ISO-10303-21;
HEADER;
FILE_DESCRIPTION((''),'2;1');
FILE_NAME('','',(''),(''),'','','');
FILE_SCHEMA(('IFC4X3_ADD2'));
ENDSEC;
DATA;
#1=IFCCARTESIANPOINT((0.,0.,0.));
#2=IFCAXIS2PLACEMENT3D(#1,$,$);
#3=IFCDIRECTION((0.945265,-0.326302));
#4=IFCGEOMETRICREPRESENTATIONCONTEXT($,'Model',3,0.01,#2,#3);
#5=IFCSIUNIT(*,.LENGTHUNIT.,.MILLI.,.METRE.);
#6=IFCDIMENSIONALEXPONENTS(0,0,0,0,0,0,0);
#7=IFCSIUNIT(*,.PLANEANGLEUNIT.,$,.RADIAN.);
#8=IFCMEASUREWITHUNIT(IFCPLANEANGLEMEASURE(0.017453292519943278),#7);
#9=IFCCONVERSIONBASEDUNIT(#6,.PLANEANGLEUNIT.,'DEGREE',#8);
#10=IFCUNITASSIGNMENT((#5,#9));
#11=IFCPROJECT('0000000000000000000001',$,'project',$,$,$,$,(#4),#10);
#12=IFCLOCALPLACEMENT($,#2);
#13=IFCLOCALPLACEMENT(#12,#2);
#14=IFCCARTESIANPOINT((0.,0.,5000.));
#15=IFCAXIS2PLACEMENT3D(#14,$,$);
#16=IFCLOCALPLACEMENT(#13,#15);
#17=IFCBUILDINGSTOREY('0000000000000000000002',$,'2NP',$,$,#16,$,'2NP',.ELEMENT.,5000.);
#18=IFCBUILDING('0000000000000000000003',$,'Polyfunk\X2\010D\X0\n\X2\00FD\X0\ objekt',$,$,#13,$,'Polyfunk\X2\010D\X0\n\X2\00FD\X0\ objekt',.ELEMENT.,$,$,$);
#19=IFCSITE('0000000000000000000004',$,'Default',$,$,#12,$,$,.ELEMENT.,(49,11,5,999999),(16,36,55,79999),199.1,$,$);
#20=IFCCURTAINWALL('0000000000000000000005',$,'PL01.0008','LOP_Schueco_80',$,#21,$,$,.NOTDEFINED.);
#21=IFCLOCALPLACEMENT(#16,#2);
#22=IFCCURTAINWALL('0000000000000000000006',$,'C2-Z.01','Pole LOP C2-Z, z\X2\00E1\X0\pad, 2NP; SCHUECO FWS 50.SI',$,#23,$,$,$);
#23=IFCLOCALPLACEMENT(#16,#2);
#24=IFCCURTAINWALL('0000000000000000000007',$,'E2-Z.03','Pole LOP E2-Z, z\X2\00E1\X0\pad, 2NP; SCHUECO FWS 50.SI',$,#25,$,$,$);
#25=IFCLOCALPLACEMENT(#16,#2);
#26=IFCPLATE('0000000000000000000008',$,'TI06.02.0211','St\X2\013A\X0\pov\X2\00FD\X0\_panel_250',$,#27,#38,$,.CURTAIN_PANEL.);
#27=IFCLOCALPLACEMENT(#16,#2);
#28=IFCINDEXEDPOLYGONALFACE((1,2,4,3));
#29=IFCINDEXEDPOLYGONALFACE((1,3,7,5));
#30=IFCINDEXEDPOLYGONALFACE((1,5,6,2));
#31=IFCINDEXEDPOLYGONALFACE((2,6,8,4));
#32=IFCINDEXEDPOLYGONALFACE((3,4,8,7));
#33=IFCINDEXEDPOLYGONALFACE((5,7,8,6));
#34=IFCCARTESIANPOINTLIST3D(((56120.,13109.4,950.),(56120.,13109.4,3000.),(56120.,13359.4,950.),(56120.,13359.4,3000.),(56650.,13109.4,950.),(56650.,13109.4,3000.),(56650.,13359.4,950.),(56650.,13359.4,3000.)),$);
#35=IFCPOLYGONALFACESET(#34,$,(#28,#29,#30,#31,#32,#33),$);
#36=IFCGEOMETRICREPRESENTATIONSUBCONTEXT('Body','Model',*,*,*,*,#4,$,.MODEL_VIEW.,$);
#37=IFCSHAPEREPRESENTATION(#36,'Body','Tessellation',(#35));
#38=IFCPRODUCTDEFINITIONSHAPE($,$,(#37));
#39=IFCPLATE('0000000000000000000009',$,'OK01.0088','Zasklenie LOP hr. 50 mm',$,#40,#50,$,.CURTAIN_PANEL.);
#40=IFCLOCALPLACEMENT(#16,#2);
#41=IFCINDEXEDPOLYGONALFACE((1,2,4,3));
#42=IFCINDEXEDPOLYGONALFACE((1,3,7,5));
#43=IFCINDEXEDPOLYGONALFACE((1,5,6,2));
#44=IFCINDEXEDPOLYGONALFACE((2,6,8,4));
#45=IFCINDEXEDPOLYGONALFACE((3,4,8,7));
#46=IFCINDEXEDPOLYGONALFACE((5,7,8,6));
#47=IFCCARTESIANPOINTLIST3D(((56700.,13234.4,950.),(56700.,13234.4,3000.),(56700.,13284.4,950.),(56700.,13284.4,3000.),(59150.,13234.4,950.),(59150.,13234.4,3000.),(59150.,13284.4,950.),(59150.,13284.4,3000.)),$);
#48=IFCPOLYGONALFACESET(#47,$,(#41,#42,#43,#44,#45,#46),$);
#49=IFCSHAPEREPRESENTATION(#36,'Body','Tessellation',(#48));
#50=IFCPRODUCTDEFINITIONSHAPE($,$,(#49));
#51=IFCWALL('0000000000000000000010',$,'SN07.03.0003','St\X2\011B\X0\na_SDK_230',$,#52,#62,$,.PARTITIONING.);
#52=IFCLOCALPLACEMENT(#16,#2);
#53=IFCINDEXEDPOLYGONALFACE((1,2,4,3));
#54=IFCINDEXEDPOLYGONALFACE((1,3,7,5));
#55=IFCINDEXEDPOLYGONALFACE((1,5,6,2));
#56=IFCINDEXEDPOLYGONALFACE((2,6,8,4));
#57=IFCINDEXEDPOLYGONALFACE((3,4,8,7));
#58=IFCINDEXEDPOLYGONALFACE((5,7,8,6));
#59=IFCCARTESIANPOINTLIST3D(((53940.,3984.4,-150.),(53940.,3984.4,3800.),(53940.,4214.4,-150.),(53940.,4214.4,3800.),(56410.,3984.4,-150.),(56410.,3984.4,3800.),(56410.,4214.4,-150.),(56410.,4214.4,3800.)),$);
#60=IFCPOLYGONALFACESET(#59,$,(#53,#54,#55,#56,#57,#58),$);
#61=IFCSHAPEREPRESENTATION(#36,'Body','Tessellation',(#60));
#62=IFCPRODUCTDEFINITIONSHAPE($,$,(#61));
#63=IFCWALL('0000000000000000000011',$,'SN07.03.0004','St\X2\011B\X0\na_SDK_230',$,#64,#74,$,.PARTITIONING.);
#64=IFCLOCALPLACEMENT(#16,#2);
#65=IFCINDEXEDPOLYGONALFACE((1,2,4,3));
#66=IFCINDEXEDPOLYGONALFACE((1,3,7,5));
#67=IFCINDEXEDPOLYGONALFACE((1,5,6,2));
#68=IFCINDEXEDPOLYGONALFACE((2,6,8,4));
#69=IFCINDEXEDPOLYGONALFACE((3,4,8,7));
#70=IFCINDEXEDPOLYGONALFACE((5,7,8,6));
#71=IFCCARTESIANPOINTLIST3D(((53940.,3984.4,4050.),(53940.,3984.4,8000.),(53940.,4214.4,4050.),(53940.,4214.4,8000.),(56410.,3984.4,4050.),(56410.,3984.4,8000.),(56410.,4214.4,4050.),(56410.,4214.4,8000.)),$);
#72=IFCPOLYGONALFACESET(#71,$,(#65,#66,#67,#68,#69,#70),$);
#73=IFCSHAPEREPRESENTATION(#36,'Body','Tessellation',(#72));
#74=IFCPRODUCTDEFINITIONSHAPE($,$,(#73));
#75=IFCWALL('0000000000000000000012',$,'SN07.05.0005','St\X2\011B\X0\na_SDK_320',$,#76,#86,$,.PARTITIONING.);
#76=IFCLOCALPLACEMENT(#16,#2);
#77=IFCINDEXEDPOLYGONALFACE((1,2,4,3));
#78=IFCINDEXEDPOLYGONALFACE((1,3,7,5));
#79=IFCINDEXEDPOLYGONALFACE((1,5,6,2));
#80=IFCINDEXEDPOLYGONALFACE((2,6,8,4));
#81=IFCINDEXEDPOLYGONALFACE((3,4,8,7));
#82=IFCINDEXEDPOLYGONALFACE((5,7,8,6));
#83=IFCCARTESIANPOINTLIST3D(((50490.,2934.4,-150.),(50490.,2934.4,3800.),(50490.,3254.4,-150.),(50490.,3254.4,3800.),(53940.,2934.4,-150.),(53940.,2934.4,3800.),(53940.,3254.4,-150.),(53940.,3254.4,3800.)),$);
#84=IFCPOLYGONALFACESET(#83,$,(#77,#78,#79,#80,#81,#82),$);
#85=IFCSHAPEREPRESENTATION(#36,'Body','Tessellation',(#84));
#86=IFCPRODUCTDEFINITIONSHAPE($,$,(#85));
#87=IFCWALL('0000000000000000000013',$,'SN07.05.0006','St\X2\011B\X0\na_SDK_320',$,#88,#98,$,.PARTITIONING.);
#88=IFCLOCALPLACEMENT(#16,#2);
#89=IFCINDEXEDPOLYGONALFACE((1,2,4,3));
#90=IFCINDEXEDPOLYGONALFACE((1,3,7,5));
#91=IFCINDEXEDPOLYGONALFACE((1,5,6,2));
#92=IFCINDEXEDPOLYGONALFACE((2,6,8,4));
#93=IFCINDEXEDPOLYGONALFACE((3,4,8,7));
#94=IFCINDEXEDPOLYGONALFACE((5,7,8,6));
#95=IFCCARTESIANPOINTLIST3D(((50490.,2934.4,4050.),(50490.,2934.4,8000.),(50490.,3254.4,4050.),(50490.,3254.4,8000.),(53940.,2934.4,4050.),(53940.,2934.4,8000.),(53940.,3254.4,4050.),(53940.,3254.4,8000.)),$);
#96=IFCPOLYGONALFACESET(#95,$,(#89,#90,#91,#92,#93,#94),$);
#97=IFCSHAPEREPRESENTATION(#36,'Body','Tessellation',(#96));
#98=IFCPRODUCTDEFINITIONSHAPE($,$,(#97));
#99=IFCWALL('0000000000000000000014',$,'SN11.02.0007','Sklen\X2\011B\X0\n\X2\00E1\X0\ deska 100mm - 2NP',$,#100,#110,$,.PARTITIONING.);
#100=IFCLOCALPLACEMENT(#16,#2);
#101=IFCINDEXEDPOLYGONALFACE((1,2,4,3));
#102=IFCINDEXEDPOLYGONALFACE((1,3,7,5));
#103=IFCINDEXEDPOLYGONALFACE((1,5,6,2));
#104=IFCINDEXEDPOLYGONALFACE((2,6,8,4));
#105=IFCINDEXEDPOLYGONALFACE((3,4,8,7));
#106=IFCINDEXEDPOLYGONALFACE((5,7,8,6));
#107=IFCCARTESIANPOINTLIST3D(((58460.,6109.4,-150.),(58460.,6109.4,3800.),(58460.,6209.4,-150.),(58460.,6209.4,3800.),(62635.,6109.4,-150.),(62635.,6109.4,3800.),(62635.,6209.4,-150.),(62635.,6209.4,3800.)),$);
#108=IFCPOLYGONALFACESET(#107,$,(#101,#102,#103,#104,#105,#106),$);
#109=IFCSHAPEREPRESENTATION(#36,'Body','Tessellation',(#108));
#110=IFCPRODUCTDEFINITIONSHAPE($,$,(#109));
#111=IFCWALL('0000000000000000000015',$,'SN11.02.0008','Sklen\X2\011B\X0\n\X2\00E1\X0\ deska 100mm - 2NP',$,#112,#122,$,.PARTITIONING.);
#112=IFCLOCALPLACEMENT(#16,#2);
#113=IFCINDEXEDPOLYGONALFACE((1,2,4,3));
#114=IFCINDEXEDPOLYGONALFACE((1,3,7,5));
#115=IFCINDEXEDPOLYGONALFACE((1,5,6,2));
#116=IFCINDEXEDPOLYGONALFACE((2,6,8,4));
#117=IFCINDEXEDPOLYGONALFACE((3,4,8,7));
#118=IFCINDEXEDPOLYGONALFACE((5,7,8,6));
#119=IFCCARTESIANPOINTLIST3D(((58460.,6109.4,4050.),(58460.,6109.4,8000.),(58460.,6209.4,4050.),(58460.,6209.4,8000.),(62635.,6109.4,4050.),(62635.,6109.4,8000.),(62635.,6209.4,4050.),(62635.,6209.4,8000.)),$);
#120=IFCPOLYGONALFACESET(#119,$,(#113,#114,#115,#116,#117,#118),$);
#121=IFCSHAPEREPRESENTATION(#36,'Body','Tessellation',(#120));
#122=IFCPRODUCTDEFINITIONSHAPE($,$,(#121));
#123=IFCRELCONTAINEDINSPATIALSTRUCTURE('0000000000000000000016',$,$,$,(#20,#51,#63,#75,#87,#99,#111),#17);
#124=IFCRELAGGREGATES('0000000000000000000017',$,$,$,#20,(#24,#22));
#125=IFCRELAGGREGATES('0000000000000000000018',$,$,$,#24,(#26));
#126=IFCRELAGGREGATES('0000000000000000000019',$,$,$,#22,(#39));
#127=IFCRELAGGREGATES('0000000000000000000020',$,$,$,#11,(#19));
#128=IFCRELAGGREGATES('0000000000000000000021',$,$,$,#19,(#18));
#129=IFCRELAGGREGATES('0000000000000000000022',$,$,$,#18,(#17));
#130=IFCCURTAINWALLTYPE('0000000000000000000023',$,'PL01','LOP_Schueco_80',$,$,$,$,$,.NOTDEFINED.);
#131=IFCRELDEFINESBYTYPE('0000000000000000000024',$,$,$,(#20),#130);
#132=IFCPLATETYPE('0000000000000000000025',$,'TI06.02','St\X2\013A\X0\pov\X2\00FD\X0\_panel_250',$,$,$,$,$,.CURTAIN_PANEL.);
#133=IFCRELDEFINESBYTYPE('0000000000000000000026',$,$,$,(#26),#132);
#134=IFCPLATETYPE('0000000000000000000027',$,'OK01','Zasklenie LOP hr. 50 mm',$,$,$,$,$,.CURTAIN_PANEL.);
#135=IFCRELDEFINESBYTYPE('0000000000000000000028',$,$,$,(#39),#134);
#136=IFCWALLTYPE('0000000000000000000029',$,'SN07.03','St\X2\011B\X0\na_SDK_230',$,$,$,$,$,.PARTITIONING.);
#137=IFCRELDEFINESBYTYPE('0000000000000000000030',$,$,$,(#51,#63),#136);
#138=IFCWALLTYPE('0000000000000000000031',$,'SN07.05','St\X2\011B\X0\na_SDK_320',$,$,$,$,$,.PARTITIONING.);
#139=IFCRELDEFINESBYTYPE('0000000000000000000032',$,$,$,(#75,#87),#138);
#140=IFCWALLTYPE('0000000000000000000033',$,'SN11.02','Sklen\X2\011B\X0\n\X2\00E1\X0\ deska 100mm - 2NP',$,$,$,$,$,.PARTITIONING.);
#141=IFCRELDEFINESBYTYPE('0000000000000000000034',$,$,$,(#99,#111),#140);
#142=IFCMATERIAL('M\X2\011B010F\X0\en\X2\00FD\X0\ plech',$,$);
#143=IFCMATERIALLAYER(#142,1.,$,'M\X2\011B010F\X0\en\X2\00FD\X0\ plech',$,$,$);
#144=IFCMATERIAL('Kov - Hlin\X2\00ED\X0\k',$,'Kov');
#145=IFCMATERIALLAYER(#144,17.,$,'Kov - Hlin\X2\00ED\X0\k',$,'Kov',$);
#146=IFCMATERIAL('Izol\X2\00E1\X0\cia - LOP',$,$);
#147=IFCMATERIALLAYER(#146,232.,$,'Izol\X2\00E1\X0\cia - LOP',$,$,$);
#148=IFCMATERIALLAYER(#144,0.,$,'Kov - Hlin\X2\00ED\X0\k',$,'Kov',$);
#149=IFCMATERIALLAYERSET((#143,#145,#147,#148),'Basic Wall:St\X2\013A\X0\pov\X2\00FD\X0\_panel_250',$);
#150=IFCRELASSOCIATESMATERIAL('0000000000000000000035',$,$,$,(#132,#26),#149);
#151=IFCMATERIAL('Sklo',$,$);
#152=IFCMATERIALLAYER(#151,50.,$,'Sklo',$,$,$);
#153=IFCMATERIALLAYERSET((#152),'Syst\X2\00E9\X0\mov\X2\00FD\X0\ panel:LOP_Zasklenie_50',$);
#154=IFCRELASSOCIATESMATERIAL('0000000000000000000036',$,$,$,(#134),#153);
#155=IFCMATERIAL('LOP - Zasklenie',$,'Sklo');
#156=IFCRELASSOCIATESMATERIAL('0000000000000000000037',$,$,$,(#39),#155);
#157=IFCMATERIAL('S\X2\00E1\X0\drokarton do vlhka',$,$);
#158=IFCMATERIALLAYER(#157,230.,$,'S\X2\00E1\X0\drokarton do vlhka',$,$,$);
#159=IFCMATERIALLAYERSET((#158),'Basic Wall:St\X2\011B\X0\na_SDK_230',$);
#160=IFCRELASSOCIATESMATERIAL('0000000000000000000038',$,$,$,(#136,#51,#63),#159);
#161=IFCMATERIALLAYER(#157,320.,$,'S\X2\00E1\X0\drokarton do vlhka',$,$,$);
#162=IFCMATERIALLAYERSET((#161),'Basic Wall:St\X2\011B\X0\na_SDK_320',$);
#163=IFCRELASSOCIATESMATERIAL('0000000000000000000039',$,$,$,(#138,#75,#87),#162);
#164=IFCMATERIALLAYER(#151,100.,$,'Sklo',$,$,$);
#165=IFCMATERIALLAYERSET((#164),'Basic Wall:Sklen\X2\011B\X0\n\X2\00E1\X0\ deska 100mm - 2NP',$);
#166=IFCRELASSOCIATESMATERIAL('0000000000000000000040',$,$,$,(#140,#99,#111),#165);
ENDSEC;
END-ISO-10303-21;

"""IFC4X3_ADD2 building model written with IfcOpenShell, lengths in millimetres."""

from ifc_helpers import new_model, entity, si_unit, converted_unit, direction, frame, frame_2d, origin, origin_2d_with_axis, place, context, subcontext, project, spatial, polyline, rectangle, extrude, clip, bounded_halfspace, source, transform, mapped, material, layer, layer_set, layer_usage, type_object, type_shapes, element, aggregate, save


model = new_model("IFC4X3_ADD2")

# Units and contexts
model_context = context("Model", 3, precision=0.01, world=origin(), true_north=direction((0.945265, -0.326302)))
body_context = subcontext(model_context, "Body", "Model", "MODEL_VIEW")
ifc_project = project(units=[si_unit("LENGTHUNIT", "METRE", prefix="MILLI"), converted_unit("PLANEANGLEUNIT", "DEGREE", entity("IfcPlaneAngleMeasure", 0.017453292519943278), si_unit("PLANEANGLEUNIT", "RADIAN"), dimensions=[0, 0, 0, 0, 0, 0, 0])], contexts=[model_context])

# Site, building, storey
site_placement = place(None, origin())
site = spatial("IfcSite", under=ifc_project, at=site_placement, Name="Default", CompositionType="ELEMENT", RefLatitude=(49, 11, 5, 999999), RefLongitude=(16, 36, 55, 79999), RefElevation=199.1)
building_placement = place(site_placement, origin())
building = spatial("IfcBuilding", under=site, at=building_placement, Name="Polyfunkčný objekt", LongName="Polyfunkčný objekt", CompositionType="ELEMENT")
storey_placement = place(building_placement, frame((0.0, 0.0, 5000.0)))
storey = spatial("IfcBuildingStorey", under=building, at=storey_placement, Name="2NP", LongName="2NP", CompositionType="ELEMENT", Elevation=5000.0)

# Curtain walls, plates
curtain_wall_type = type_object("IfcCurtainWallType", Name="PL01", Description="LOP_Schueco_80", PredefinedType="NOTDEFINED")
curtain_wall_1_placement = place(storey_placement, frame((0.0, 0.0, -5000.0)))
curtain_wall_1 = element("IfcCurtainWall", 1, at=curtain_wall_1_placement, inside=storey, type_object=curtain_wall_type, Name="PL01.0008", Description="LOP_Schueco_80", PredefinedType="NOTDEFINED")
curtain_wall_2 = element("IfcCurtainWall", 2, Name="C2-Z.01", Description="Pole LOP C2-Z, západ, 2NP; SCHUECO FWS 50.SI")
curtain_wall_3 = element("IfcCurtainWall", 3, Name="E2-Z.03", Description="Pole LOP E2-Z, západ, 2NP; SCHUECO FWS 50.SI")
aggregate(curtain_wall_1, [curtain_wall_3, curtain_wall_2])
ifc_material_1 = material(Name="Měďený plech")
ifc_layer_1 = layer(ifc_material_1, 1.0, Name="Měďený plech")
ifc_material_2 = material(Name="Kov - Hliník", Category="Kov")
ifc_layer_2 = layer(ifc_material_2, 17.0, Name="Kov - Hliník", Category="Kov")
ifc_material_3 = material(Name="Izolácia - LOP")
ifc_layer_3 = layer(ifc_material_3, 232.0, Name="Izolácia - LOP")
ifc_layer_4 = layer(ifc_material_2, 0.0, Name="Kov - Hliník", Category="Kov")
ifc_layer_set_1 = layer_set([ifc_layer_1, ifc_layer_2, ifc_layer_3, ifc_layer_4], Name="Basic Wall:Stĺpový_panel_250")
ifc_layer_usage = layer_usage(ifc_layer_set_1, "AXIS2", "NEGATIVE", 125.0)
plate_type_1 = type_object("IfcPlateType", Name="TI06.02", Description="Stĺpový_panel_250", PredefinedType="CURTAIN_PANEL", material=ifc_layer_set_1)
plate_1_placement = place(storey_placement, frame((56120.0, 13234.4, 950.0)))
plate_1 = element("IfcPlate", 4, at=plate_1_placement, type_object=plate_type_1, material=ifc_layer_usage, Name="TI06.02.0211", Description="Stĺpový_panel_250", PredefinedType="CURTAIN_PANEL", context=body_context, shape_type="SweptSolid", body=[
    extrude(rectangle(XDim=250.0, YDim=530.0, at=frame_2d((0.0, 0.0), x_axis=(1.0, 0.0))), frame((265.0, 0.0, 0.0), z_axis=(0.0, 0.0, 1.0), x_axis=(0.0, 1.0, 0.0)), (0.0, 0.0, 1.0), 2050.0),
])
aggregate(curtain_wall_3, [plate_1])
ifc_material_4 = material(Name="LOP - Zasklenie", Category="Sklo")
ifc_material_5 = material(Name="Sklo")
ifc_layer_5 = layer(ifc_material_5, 50.0, Name="Sklo")
ifc_layer_set_2 = layer_set([ifc_layer_5], Name="Systémový panel:LOP_Zasklenie_50")
plate_type_2 = type_object("IfcPlateType", Name="OK01", Description="Zasklenie LOP hr. 50 mm", PredefinedType="CURTAIN_PANEL", material=ifc_layer_set_2)
shared_shape_1 = source(origin(), body_context, "Body", "SweptSolid", [
    extrude(rectangle(XDim=50.0, YDim=2450.0, at=origin_2d_with_axis()), frame((0.0, 25.0, 0.0), z_axis=(0.0, 0.0, 1.0), x_axis=(0.0, 1.0, 0.0)), (0.0, 0.0, 1.0), 2050.0),
])
type_shapes(plate_type_2, [shared_shape_1])
plate_2_placement = place(curtain_wall_1_placement, frame((57925.0, 13234.4, 5950.0)))
plate_2 = element("IfcPlate", 5, at=plate_2_placement, type_object=plate_type_2, material=ifc_material_4, Name="OK01.0088", Description="Zasklenie LOP hr. 50 mm", PredefinedType="CURTAIN_PANEL", context=body_context, shape_type="MappedRepresentation", body=[
    mapped(shared_shape_1, transform((0.0, 0.0, 0.0), scale=1.0)),
])
aggregate(curtain_wall_2, [plate_2])

# Walls
ifc_material_6 = material(Name="Sádrokarton do vlhka")
ifc_layer_6 = layer(ifc_material_6, 230.0, Name="Sádrokarton do vlhka")
ifc_layer_set_3 = layer_set([ifc_layer_6], Name="Basic Wall:Stěna_SDK_230")
wall_type_1 = type_object("IfcWallType", Name="SN07.03", Description="Stěna_SDK_230", PredefinedType="PARTITIONING", material=ifc_layer_set_3)
wall_1_placement = place(storey_placement, frame((56410.0, 4099.4, -150.0), z_axis=(0.0, 0.0, 1.0), x_axis=(-1.0, 0.0, 0.0)))
element("IfcWall", 6, at=wall_1_placement, inside=storey, type_object=wall_type_1, material=ifc_layer_set_3, Name="SN07.03.0003", Description="Stěna_SDK_230", PredefinedType="PARTITIONING", context=body_context, shape_type="Clipping", body=[
    clip(clip(extrude(rectangle(XDim=2470.0, YDim=230.0, at=frame_2d((1235.0, 0.0), x_axis=(-1.0, 0.0))), origin(), (0.0, 0.0, 1.0), 3950.0), bounded_halfspace(frame((2470.0, -115.0, 0.0)), True, frame((2470.0, -115.0, 0.0)), polyline([(0.0, 0.0), (0.0, 60.0), (0.0, 230.0), (-320.0, 230.0), (-2470.0, 230.0), (-2470.0, 0.0), (-150.0, 0.0), (0.0, 0.0)]))), bounded_halfspace(frame((0.0, -115.0, 3950.0), z_axis=(0.0, 0.0, -1.0), x_axis=(-1.0, 0.0, 0.0)), True, frame((0.0, -115.0, 3950.0)), polyline([(0.0, 0.0), (2320.0, 0.0), (2470.0, 0.0), (2470.0, 60.0), (2470.0, 230.0), (2150.0, 230.0), (0.0, 230.0), (0.0, 0.0)]))),
])
wall_2_placement = place(storey_placement, frame((56410.0, 4099.4, 4050.0), z_axis=(0.0, 0.0, 1.0), x_axis=(-1.0, 0.0, 0.0)))
element("IfcWall", 7, at=wall_2_placement, inside=storey, type_object=wall_type_1, material=ifc_layer_set_3, Name="SN07.03.0004", Description="Stěna_SDK_230", PredefinedType="PARTITIONING", context=body_context, shape_type="Clipping", body=[
    clip(clip(extrude(rectangle(XDim=2470.0, YDim=230.0, at=frame_2d((1235.0, 0.0), x_axis=(-1.0, 0.0))), origin(), (0.0, 0.0, 1.0), 3950.0), bounded_halfspace(frame((2470.0, -115.0, 0.0)), True, frame((2470.0, -115.0, 0.0)), polyline([(0.0, 0.0), (0.0, 60.0), (0.0, 230.0), (-320.0, 230.0), (-2470.0, 230.0), (-2470.0, 0.0), (-150.0, 0.0), (0.0, 0.0)]))), bounded_halfspace(frame((0.0, -115.0, 3950.0), z_axis=(0.0, 0.0, -1.0), x_axis=(-1.0, 0.0, 0.0)), True, frame((0.0, -115.0, 3950.0)), polyline([(0.0, 0.0), (2320.0, 0.0), (2470.0, 0.0), (2470.0, 60.0), (2470.0, 230.0), (2150.0, 230.0), (0.0, 230.0), (0.0, 0.0)]))),
])
ifc_layer_7 = layer(ifc_material_6, 320.0, Name="Sádrokarton do vlhka")
ifc_layer_set_4 = layer_set([ifc_layer_7], Name="Basic Wall:Stěna_SDK_320")
wall_type_2 = type_object("IfcWallType", Name="SN07.05", Description="Stěna_SDK_320", PredefinedType="PARTITIONING", material=ifc_layer_set_4)
wall_3_placement = place(storey_placement, frame((53940.0, 3094.4, -150.0), z_axis=(0.0, 0.0, 1.0), x_axis=(-1.0, 0.0, 0.0)))
element("IfcWall", 8, at=wall_3_placement, inside=storey, type_object=wall_type_2, material=ifc_layer_set_4, Name="SN07.05.0005", Description="Stěna_SDK_320", PredefinedType="PARTITIONING", context=body_context, shape_type="Clipping", body=[
    clip(clip(extrude(rectangle(XDim=3450.0, YDim=320.0, at=frame_2d((1725.0, 0.0), x_axis=(-1.0, 0.0))), origin(), (0.0, 0.0, 1.0), 3950.0), bounded_halfspace(frame((3450.0, -160.0, 0.0)), True, frame((3450.0, -160.0, 0.0)), polyline([(0.0, 0.0), (0.0, 320.0), (-1650.0, 320.0), (-1800.0, 320.0), (-3450.0, 320.0), (-3450.0, 0.0), (-1800.0, 0.0), (-1650.0, 0.0), (0.0, 0.0)]))), bounded_halfspace(frame((0.0, -160.0, 3950.0), z_axis=(0.0, 0.0, -1.0), x_axis=(-1.0, 0.0, 0.0)), True, frame((0.0, -160.0, 3950.0)), polyline([(0.0, 0.0), (1650.0, 0.0), (1800.0, 0.0), (3450.0, 0.0), (3450.0, 320.0), (1800.0, 320.0), (1650.0, 320.0), (0.0, 320.0), (0.0, 0.0)]))),
])
wall_4_placement = place(storey_placement, frame((53940.0, 3094.4, 4050.0), z_axis=(0.0, 0.0, 1.0), x_axis=(-1.0, 0.0, 0.0)))
element("IfcWall", 9, at=wall_4_placement, inside=storey, type_object=wall_type_2, material=ifc_layer_set_4, Name="SN07.05.0006", Description="Stěna_SDK_320", PredefinedType="PARTITIONING", context=body_context, shape_type="Clipping", body=[
    clip(clip(extrude(rectangle(XDim=3450.0, YDim=320.0, at=frame_2d((1725.0, 0.0), x_axis=(-1.0, 0.0))), origin(), (0.0, 0.0, 1.0), 3950.0), bounded_halfspace(frame((3450.0, -160.0, 0.0)), True, frame((3450.0, -160.0, 0.0)), polyline([(0.0, 0.0), (0.0, 320.0), (-1650.0, 320.0), (-1800.0, 320.0), (-3450.0, 320.0), (-3450.0, 0.0), (-1800.0, 0.0), (-1650.0, 0.0), (0.0, 0.0)]))), bounded_halfspace(frame((0.0, -160.0, 3950.0), z_axis=(0.0, 0.0, -1.0), x_axis=(-1.0, 0.0, 0.0)), True, frame((0.0, -160.0, 3950.0)), polyline([(0.0, 0.0), (1650.0, 0.0), (1800.0, 0.0), (3450.0, 0.0), (3450.0, 320.0), (1800.0, 320.0), (1650.0, 320.0), (0.0, 320.0), (0.0, 0.0)]))),
])
ifc_layer_8 = layer(ifc_material_5, 100.0, Name="Sklo")
ifc_layer_set_5 = layer_set([ifc_layer_8], Name="Basic Wall:Skleněná deska 100mm - 2NP")
wall_type_3 = type_object("IfcWallType", Name="SN11.02", Description="Skleněná deska 100mm - 2NP", PredefinedType="PARTITIONING", material=ifc_layer_set_5)
wall_5_placement = place(storey_placement, frame((58460.0, 6159.4, -150.0)))
element("IfcWall", 10, at=wall_5_placement, inside=storey, type_object=wall_type_3, material=ifc_layer_set_5, Name="SN11.02.0007", Description="Skleněná deska 100mm - 2NP", PredefinedType="PARTITIONING", context=body_context, shape_type="Clipping", body=[
    clip(clip(extrude(rectangle(XDim=4175.0, YDim=100.0, at=frame_2d((2087.5, 0.0), x_axis=(-1.0, 0.0))), origin(), (0.0, 0.0, 1.0), 3950.0), bounded_halfspace(frame((4175.0, -50.0, 0.0), z_axis=(0.0, 0.0, 1.0), x_axis=(-1.0, 0.0, 0.0)), True, frame((4175.0, -50.0, 0.0)), polyline([(0.0, 0.0), (0.0, 100.0), (-4175.0, 100.0), (-4175.0, 0.0), (-4075.0, 0.0), (0.0, 0.0)]))), bounded_halfspace(frame((0.0, -50.0, 3950.0), z_axis=(0.0, 0.0, -1.0), x_axis=(1.0, 0.0, 0.0)), True, frame((0.0, -50.0, 3950.0)), polyline([(0.0, 0.0), (100.0, 0.0), (4175.0, 0.0), (4175.0, 100.0), (0.0, 100.0), (0.0, 0.0)]))),
])
wall_6_placement = place(storey_placement, frame((58460.0, 6159.4, 4050.0)))
element("IfcWall", 11, at=wall_6_placement, inside=storey, type_object=wall_type_3, material=ifc_layer_set_5, Name="SN11.02.0008", Description="Skleněná deska 100mm - 2NP", PredefinedType="PARTITIONING", context=body_context, shape_type="Clipping", body=[
    clip(clip(extrude(rectangle(XDim=4175.0, YDim=100.0, at=frame_2d((2087.5, 0.0), x_axis=(-1.0, 0.0))), origin(), (0.0, 0.0, 1.0), 3950.0), bounded_halfspace(frame((4175.0, -50.0, 0.0), z_axis=(0.0, 0.0, 1.0), x_axis=(-1.0, 0.0, 0.0)), True, frame((4175.0, -50.0, 0.0)), polyline([(0.0, 0.0), (0.0, 100.0), (-4175.0, 100.0), (-4175.0, 0.0), (-4075.0, 0.0), (0.0, 0.0)]))), bounded_halfspace(frame((0.0, -50.0, 3950.0), z_axis=(0.0, 0.0, -1.0), x_axis=(1.0, 0.0, 0.0)), True, frame((0.0, -50.0, 3950.0)), polyline([(0.0, 0.0), (100.0, 0.0), (4175.0, 0.0), (4175.0, 100.0), (0.0, 100.0), (0.0, 0.0)]))),
])

save(model, "model.ifc")
